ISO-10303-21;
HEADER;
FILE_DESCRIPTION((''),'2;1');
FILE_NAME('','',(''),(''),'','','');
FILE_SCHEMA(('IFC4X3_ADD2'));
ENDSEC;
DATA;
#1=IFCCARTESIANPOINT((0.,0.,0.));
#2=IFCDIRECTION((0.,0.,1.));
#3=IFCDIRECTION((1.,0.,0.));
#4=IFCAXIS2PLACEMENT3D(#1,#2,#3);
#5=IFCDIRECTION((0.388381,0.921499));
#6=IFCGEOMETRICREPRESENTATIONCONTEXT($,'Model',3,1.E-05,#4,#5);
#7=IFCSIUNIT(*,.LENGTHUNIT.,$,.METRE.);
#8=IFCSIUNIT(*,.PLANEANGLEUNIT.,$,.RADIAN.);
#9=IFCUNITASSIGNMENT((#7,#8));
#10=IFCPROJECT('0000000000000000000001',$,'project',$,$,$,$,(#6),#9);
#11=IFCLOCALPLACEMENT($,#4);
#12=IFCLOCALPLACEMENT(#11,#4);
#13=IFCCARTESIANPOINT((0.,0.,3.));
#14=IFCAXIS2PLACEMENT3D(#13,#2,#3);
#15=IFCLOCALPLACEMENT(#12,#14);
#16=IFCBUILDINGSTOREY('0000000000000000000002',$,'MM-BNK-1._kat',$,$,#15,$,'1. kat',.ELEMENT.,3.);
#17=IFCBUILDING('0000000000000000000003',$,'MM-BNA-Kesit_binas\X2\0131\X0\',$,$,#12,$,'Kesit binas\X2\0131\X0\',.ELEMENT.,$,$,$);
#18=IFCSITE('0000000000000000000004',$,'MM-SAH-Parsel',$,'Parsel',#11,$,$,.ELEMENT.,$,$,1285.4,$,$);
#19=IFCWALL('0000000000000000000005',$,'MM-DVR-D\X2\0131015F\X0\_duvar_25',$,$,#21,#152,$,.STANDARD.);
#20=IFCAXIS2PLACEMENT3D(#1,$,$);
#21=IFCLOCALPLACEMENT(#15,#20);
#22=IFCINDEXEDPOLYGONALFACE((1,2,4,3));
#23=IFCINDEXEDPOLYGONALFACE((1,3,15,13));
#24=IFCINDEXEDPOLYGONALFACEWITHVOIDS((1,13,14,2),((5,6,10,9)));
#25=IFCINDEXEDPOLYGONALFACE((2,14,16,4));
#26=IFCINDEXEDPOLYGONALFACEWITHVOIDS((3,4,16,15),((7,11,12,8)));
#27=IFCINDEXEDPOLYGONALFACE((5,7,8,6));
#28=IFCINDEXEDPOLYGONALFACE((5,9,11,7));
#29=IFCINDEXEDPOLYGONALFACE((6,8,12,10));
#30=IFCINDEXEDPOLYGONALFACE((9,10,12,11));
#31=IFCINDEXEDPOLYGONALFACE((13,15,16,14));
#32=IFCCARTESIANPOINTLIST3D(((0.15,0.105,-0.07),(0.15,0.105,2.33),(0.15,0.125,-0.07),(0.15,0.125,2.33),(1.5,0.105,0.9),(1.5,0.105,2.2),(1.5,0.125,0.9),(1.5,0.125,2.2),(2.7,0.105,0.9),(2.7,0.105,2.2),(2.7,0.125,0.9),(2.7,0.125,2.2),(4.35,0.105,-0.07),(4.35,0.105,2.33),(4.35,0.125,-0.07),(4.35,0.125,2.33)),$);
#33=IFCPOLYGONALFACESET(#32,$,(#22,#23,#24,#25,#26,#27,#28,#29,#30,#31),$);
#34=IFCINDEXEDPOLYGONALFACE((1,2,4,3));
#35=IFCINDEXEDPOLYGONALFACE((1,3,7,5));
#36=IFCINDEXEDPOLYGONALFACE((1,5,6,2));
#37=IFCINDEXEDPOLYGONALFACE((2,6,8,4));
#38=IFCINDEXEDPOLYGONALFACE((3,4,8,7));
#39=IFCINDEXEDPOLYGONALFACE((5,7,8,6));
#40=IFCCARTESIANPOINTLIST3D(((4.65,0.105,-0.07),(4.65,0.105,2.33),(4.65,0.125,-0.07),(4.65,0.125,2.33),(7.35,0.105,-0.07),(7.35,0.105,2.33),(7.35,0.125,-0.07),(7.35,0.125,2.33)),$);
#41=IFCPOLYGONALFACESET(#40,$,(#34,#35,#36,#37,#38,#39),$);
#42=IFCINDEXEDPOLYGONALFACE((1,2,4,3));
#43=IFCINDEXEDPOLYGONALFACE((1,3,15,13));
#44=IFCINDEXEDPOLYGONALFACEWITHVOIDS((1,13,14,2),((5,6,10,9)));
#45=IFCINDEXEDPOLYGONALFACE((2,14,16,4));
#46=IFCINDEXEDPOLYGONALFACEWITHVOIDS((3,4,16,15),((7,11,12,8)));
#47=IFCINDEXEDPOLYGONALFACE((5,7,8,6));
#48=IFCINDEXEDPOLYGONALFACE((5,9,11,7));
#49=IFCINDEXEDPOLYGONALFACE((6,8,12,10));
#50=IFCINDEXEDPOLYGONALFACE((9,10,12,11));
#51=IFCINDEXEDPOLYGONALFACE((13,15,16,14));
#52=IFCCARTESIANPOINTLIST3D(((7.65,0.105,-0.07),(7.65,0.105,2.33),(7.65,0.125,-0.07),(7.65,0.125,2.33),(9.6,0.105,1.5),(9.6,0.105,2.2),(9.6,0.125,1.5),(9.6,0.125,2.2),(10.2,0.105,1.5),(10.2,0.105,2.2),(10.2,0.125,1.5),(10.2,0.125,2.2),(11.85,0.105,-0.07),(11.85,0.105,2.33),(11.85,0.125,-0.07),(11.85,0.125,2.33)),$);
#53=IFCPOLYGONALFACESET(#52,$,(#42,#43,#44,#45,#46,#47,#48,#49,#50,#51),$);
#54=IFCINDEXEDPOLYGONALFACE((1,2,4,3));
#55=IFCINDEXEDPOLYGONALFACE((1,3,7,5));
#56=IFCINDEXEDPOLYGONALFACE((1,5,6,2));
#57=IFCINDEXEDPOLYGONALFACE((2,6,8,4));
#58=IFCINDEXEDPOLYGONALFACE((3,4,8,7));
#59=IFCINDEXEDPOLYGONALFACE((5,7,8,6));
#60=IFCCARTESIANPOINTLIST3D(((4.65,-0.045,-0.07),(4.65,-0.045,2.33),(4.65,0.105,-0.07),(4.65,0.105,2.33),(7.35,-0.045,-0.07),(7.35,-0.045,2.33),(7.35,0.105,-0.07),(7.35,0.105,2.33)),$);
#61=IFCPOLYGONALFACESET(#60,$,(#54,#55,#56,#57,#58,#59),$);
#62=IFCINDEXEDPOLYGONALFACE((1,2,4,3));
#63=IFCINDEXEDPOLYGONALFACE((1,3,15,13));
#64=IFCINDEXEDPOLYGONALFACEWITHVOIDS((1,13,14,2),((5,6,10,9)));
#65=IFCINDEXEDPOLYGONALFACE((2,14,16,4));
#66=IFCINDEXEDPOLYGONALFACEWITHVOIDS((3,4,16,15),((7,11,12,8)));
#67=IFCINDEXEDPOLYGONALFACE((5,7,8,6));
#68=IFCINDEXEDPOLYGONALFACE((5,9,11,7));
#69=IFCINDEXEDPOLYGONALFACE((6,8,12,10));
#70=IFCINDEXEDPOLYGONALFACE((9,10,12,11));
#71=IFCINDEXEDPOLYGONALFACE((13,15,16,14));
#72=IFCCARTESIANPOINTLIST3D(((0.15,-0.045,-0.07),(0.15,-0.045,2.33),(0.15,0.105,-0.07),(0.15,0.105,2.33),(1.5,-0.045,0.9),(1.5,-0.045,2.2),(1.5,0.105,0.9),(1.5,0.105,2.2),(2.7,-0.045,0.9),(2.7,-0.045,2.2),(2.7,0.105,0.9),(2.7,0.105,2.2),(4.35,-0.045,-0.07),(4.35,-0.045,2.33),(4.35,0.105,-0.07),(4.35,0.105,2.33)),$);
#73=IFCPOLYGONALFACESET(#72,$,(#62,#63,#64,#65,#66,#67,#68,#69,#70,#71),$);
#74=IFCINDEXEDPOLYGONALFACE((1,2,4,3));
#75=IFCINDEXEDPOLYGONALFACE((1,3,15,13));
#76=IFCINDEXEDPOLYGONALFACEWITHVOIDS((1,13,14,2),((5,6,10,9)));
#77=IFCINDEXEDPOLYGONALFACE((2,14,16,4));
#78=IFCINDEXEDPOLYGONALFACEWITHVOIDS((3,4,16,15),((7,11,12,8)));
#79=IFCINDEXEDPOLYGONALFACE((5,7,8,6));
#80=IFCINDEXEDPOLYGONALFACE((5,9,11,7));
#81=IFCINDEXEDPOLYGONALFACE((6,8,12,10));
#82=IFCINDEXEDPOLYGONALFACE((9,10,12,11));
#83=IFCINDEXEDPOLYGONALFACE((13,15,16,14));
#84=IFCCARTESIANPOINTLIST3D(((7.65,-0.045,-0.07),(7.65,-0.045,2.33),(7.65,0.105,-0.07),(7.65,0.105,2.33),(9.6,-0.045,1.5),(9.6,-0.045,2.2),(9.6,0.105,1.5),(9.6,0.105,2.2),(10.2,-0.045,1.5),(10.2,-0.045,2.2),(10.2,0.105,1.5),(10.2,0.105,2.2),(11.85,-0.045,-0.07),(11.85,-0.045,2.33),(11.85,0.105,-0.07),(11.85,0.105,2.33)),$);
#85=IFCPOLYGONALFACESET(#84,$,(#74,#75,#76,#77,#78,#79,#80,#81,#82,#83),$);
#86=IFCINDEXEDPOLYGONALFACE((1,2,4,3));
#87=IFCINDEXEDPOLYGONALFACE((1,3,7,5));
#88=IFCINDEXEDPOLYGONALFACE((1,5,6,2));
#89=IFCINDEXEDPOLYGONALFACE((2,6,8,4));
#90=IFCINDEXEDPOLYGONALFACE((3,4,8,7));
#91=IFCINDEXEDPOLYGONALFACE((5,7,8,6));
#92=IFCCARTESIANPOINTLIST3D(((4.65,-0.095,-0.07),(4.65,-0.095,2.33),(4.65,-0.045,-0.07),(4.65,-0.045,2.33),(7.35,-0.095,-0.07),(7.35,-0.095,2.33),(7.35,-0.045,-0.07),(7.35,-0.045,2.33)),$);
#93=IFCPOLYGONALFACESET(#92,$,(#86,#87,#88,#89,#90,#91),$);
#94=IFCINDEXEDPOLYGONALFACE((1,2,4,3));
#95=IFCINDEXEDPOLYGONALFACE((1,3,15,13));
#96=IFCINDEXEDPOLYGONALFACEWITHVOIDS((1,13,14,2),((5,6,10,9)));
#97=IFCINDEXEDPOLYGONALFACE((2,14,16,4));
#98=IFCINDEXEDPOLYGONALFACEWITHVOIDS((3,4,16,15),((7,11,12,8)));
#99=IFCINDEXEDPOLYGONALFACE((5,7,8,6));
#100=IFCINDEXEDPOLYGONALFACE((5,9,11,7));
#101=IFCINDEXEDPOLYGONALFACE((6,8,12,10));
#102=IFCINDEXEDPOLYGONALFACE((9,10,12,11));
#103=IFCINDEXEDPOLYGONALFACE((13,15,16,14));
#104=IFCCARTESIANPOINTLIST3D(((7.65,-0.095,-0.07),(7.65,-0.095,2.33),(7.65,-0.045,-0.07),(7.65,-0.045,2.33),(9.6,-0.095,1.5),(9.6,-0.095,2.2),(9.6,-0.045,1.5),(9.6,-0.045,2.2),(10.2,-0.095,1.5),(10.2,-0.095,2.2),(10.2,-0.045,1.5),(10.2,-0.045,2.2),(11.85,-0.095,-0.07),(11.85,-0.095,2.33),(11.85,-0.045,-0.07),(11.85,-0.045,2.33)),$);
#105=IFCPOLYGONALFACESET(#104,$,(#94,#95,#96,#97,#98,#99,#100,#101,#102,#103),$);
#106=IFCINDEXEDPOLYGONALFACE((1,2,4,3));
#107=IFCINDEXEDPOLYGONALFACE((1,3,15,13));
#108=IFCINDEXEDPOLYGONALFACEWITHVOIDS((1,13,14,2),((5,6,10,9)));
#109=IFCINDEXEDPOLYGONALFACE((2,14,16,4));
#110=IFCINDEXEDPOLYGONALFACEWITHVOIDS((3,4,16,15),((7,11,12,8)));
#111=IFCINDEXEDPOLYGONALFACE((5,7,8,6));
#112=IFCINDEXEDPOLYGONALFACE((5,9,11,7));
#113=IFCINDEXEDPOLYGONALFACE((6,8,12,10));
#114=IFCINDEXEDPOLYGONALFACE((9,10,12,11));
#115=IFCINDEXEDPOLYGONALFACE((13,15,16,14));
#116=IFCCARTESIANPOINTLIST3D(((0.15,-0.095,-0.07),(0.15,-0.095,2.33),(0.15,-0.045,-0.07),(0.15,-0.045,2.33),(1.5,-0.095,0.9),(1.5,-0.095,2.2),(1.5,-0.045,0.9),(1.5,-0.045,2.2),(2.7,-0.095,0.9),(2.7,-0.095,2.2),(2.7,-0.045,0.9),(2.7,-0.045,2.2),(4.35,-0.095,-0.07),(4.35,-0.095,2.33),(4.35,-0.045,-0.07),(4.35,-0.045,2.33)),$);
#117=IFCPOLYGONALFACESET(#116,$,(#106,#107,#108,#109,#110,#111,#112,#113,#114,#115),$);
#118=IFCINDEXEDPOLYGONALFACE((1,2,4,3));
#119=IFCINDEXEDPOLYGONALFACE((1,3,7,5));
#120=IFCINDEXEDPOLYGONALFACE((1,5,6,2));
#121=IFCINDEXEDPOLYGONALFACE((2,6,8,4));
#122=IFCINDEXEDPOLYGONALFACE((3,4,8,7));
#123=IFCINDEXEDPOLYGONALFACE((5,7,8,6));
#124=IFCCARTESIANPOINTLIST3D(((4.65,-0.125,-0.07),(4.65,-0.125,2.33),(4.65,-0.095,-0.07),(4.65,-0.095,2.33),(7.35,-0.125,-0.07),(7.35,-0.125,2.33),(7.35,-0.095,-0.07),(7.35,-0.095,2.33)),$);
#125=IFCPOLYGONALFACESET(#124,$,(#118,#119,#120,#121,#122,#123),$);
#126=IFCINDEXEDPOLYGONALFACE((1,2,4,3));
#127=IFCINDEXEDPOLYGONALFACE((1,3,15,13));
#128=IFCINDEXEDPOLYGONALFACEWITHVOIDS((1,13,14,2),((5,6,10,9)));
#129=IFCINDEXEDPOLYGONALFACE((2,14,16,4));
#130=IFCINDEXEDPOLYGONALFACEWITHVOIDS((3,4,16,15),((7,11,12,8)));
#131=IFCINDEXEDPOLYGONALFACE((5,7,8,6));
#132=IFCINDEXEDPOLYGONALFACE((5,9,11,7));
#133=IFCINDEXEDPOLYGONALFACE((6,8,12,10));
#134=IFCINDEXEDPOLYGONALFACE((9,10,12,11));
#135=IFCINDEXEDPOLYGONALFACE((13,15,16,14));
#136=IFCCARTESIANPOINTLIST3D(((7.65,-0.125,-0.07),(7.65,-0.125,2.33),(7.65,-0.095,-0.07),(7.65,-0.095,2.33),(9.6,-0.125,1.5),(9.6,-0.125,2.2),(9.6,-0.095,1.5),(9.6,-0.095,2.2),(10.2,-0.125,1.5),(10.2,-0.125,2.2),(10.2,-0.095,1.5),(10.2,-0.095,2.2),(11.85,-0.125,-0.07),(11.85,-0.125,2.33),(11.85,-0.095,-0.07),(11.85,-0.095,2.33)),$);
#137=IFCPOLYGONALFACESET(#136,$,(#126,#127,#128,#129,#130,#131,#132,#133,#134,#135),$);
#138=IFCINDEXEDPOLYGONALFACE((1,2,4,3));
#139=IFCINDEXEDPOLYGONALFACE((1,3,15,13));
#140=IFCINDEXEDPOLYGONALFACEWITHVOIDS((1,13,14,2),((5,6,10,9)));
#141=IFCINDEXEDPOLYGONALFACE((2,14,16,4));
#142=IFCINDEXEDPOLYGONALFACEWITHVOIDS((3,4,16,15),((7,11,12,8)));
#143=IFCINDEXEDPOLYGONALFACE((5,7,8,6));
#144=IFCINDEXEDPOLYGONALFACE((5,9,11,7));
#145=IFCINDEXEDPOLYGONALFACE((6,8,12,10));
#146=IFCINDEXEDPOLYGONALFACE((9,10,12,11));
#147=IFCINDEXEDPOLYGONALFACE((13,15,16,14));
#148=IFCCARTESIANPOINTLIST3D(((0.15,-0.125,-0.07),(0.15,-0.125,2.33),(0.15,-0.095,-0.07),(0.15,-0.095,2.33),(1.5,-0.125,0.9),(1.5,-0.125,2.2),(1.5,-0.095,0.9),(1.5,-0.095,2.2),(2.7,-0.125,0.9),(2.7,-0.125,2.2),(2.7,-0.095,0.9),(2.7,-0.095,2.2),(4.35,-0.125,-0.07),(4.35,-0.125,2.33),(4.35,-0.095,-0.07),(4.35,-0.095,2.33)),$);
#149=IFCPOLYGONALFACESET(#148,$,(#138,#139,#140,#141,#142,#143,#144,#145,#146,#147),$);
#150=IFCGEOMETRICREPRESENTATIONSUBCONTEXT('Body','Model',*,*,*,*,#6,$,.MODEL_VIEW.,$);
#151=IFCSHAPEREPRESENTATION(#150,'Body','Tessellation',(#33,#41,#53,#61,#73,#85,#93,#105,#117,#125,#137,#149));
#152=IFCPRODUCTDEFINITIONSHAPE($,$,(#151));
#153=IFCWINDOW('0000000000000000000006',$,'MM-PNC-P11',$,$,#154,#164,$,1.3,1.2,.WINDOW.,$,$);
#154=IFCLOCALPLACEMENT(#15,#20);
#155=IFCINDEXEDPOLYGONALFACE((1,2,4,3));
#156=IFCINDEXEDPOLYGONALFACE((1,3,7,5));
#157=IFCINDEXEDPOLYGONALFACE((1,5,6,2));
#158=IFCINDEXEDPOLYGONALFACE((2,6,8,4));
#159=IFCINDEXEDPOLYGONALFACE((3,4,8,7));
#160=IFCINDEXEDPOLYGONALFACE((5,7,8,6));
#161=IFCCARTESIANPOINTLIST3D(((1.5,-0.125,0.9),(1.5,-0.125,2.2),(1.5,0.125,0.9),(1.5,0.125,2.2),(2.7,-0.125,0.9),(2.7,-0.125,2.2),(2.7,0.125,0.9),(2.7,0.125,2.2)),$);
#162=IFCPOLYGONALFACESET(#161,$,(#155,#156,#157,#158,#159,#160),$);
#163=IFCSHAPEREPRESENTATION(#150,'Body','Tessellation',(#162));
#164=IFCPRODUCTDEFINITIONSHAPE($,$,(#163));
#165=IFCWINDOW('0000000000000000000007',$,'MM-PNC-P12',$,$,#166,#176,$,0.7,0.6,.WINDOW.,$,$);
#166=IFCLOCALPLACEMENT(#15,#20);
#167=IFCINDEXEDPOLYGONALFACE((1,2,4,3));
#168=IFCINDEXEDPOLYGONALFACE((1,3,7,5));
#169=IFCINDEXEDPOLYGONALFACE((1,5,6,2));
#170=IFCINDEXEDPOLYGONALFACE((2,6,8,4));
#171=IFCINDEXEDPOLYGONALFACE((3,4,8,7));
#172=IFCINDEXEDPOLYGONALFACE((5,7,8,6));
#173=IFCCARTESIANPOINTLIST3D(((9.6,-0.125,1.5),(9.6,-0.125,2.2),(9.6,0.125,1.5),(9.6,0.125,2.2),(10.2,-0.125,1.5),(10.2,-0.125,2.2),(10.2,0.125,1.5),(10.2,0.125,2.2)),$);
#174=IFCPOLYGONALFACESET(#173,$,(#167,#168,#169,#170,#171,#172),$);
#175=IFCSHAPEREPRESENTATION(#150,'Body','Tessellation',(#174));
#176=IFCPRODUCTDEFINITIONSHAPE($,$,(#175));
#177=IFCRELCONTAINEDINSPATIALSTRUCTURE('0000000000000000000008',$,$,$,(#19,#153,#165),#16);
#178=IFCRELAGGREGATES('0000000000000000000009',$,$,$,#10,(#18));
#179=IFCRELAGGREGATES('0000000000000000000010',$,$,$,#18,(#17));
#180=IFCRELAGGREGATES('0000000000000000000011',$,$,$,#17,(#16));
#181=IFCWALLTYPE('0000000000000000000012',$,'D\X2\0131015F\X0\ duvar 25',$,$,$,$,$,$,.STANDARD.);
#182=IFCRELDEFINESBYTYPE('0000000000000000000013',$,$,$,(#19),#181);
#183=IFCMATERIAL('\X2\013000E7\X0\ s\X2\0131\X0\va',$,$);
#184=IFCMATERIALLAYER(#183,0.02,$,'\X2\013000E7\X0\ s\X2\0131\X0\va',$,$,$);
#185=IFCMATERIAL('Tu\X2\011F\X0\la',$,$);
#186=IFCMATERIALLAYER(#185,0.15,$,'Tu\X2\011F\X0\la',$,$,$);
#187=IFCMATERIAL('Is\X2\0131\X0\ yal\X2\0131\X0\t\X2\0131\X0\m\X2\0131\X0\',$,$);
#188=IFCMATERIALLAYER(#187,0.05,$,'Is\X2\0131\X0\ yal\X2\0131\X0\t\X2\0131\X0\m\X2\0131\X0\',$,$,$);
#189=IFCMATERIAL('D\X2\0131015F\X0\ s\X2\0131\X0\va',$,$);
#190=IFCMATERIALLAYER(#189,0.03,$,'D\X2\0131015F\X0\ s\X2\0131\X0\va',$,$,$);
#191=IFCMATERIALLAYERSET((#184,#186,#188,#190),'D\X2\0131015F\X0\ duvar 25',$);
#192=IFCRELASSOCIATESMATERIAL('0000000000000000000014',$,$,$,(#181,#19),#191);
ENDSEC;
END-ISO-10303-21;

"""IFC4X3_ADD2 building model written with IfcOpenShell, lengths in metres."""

from ifc_helpers import new_model, si_unit, direction, frame, origin_with_axes, place, context, subcontext, project, spatial, polyline, outline, extrude, material, layer, layer_set, type_object, element, fill, save


model = new_model("IFC4X3_ADD2")

# Units and contexts
model_context = context("Model", 3, precision=1e-05, world=origin_with_axes(), true_north=direction((0.388381, 0.921499)))
body_context = subcontext(model_context, "Body", "Model", "MODEL_VIEW")
ifc_project = project(units=[si_unit("LENGTHUNIT", "METRE"), si_unit("PLANEANGLEUNIT", "RADIAN")], contexts=[model_context])

# Site, building, storey
site_placement = place(None, origin_with_axes())
site = spatial("IfcSite", under=ifc_project, at=site_placement, Name="MM-SAH-Parsel", ObjectType="Parsel", CompositionType="ELEMENT", RefElevation=1285.4)
building_placement = place(site_placement, origin_with_axes())
building = spatial("IfcBuilding", under=site, at=building_placement, Name="MM-BNA-Kesit_binası", LongName="Kesit binası", CompositionType="ELEMENT")
storey_placement = place(building_placement, frame((0.0, 0.0, 3.0), z_axis=(0.0, 0.0, 1.0), x_axis=(1.0, 0.0, 0.0)))
storey = spatial("IfcBuildingStorey", under=building, at=storey_placement, Name="MM-BNK-1._kat", LongName="1. kat", CompositionType="ELEMENT", Elevation=3.0)

# Wall, openings, windows
ifc_material_1 = material(Name="İç sıva")
ifc_layer_1 = layer(ifc_material_1, 0.02, Name="İç sıva")
ifc_material_2 = material(Name="Tuğla")
ifc_layer_2 = layer(ifc_material_2, 0.15, Name="Tuğla")
ifc_material_3 = material(Name="Isı yalıtımı")
ifc_layer_3 = layer(ifc_material_3, 0.05, Name="Isı yalıtımı")
ifc_material_4 = material(Name="Dış sıva")
ifc_layer_4 = layer(ifc_material_4, 0.03, Name="Dış sıva")
ifc_layer_set_1 = layer_set([ifc_layer_1, ifc_layer_2, ifc_layer_3, ifc_layer_4], Name="Dış duvar 25")
wall_type_1 = type_object("IfcWallType", Name="Dış duvar 25", PredefinedType="STANDARD", material=ifc_layer_set_1)
wall_1_placement = place(storey_placement, origin_with_axes())
wall_1 = element("IfcWall", 1, at=wall_1_placement, inside=storey, type_object=wall_type_1, material=ifc_layer_set_1, Name="MM-DVR-Dış_duvar_25", PredefinedType="STANDARD", context=body_context, shape_type="SweptSolid", body=[
    extrude(outline(polyline([(0.15, 0.105), (4.35, 0.105), (4.35, 0.125), (0.15, 0.125), (0.15, 0.105)])), frame((0.0, 0.0, -0.07)), (0.0, 0.0, 1.0), 2.4),
    extrude(outline(polyline([(4.65, 0.105), (7.35, 0.105), (7.35, 0.125), (4.65, 0.125), (4.65, 0.105)])), frame((0.0, 0.0, -0.07)), (0.0, 0.0, 1.0), 2.4),
    extrude(outline(polyline([(7.65, 0.105), (11.85, 0.105), (11.85, 0.125), (7.65, 0.125), (7.65, 0.105)])), frame((0.0, 0.0, -0.07)), (0.0, 0.0, 1.0), 2.4),
    extrude(outline(polyline([(4.65, -0.045), (7.35, -0.045), (7.35, 0.105), (4.65, 0.105), (4.65, -0.045)])), frame((0.0, 0.0, -0.07)), (0.0, 0.0, 1.0), 2.4),
    extrude(outline(polyline([(0.15, -0.045), (4.35, -0.045), (4.35, 0.105), (0.15, 0.105), (0.15, -0.045)])), frame((0.0, 0.0, -0.07)), (0.0, 0.0, 1.0), 2.4),
    extrude(outline(polyline([(7.65, -0.045), (11.85, -0.045), (11.85, 0.105), (7.65, 0.105), (7.65, -0.045)])), frame((0.0, 0.0, -0.07)), (0.0, 0.0, 1.0), 2.4),
    extrude(outline(polyline([(4.65, -0.095), (7.35, -0.095), (7.35, -0.045), (4.65, -0.045), (4.65, -0.095)])), frame((0.0, 0.0, -0.07)), (0.0, 0.0, 1.0), 2.4),
    extrude(outline(polyline([(7.65, -0.095), (11.85, -0.095), (11.85, -0.045), (7.65, -0.045), (7.65, -0.095)])), frame((0.0, 0.0, -0.07)), (0.0, 0.0, 1.0), 2.4),
    extrude(outline(polyline([(0.15, -0.095), (4.35, -0.095), (4.35, -0.045), (0.15, -0.045), (0.15, -0.095)])), frame((0.0, 0.0, -0.07)), (0.0, 0.0, 1.0), 2.4),
    extrude(outline(polyline([(4.65, -0.125), (7.35, -0.125), (7.35, -0.095), (4.65, -0.095), (4.65, -0.125)])), frame((0.0, 0.0, -0.07)), (0.0, 0.0, 1.0), 2.4),
    extrude(outline(polyline([(7.65, -0.125), (11.85, -0.125), (11.85, -0.095), (7.65, -0.095), (7.65, -0.125)])), frame((0.0, 0.0, -0.07)), (0.0, 0.0, 1.0), 2.4),
    extrude(outline(polyline([(0.15, -0.125), (4.35, -0.125), (4.35, -0.095), (0.15, -0.095), (0.15, -0.125)])), frame((0.0, 0.0, -0.07)), (0.0, 0.0, 1.0), 2.4),
])
opening_1_placement = place(storey_placement, origin_with_axes())
opening_1 = element("IfcOpeningElement", 2, at=opening_1_placement, cuts=wall_1, PredefinedType="OPENING", context=body_context, shape_type="SweptSolid", body=[
    extrude(outline(polyline([(1.5, 0.125), (2.7, 0.125), (2.7, -0.125), (1.5, -0.125), (1.5, 0.125)])), frame((0.0, 0.0, 0.9)), (0.0, 0.0, 1.0), 1.3),
])
opening_2_placement = place(storey_placement, origin_with_axes())
opening_2 = element("IfcOpeningElement", 3, at=opening_2_placement, cuts=wall_1, PredefinedType="OPENING", context=body_context, shape_type="SweptSolid", body=[
    extrude(outline(polyline([(9.6, 0.125), (10.2, 0.125), (10.2, -0.125), (9.6, -0.125), (9.6, 0.125)])), frame((0.0, 0.0, 1.5)), (0.0, 0.0, 1.0), 0.7),
])
window_1_placement = place(storey_placement, origin_with_axes())
window_1 = element("IfcWindow", 4, at=window_1_placement, inside=storey, Name="MM-PNC-P11", OverallHeight=1.3, OverallWidth=1.2, PredefinedType="WINDOW", context=body_context, shape_type="SweptSolid", body=[
    extrude(outline(polyline([(1.5, 0.125), (2.7, 0.125), (2.7, -0.125), (1.5, -0.125), (1.5, 0.125)])), frame((0.0, 0.0, 0.9)), (0.0, 0.0, 1.0), 1.3),
])
fill(opening_1, window_1)
window_2_placement = place(storey_placement, origin_with_axes())
window_2 = element("IfcWindow", 5, at=window_2_placement, inside=storey, Name="MM-PNC-P12", OverallHeight=0.7, OverallWidth=0.6, PredefinedType="WINDOW", context=body_context, shape_type="SweptSolid", body=[
    extrude(outline(polyline([(9.6, 0.125), (10.2, 0.125), (10.2, -0.125), (9.6, -0.125), (9.6, 0.125)])), frame((0.0, 0.0, 1.5)), (0.0, 0.0, 1.0), 0.7),
])
fill(opening_2, window_2)

save(model, "model.ifc")
